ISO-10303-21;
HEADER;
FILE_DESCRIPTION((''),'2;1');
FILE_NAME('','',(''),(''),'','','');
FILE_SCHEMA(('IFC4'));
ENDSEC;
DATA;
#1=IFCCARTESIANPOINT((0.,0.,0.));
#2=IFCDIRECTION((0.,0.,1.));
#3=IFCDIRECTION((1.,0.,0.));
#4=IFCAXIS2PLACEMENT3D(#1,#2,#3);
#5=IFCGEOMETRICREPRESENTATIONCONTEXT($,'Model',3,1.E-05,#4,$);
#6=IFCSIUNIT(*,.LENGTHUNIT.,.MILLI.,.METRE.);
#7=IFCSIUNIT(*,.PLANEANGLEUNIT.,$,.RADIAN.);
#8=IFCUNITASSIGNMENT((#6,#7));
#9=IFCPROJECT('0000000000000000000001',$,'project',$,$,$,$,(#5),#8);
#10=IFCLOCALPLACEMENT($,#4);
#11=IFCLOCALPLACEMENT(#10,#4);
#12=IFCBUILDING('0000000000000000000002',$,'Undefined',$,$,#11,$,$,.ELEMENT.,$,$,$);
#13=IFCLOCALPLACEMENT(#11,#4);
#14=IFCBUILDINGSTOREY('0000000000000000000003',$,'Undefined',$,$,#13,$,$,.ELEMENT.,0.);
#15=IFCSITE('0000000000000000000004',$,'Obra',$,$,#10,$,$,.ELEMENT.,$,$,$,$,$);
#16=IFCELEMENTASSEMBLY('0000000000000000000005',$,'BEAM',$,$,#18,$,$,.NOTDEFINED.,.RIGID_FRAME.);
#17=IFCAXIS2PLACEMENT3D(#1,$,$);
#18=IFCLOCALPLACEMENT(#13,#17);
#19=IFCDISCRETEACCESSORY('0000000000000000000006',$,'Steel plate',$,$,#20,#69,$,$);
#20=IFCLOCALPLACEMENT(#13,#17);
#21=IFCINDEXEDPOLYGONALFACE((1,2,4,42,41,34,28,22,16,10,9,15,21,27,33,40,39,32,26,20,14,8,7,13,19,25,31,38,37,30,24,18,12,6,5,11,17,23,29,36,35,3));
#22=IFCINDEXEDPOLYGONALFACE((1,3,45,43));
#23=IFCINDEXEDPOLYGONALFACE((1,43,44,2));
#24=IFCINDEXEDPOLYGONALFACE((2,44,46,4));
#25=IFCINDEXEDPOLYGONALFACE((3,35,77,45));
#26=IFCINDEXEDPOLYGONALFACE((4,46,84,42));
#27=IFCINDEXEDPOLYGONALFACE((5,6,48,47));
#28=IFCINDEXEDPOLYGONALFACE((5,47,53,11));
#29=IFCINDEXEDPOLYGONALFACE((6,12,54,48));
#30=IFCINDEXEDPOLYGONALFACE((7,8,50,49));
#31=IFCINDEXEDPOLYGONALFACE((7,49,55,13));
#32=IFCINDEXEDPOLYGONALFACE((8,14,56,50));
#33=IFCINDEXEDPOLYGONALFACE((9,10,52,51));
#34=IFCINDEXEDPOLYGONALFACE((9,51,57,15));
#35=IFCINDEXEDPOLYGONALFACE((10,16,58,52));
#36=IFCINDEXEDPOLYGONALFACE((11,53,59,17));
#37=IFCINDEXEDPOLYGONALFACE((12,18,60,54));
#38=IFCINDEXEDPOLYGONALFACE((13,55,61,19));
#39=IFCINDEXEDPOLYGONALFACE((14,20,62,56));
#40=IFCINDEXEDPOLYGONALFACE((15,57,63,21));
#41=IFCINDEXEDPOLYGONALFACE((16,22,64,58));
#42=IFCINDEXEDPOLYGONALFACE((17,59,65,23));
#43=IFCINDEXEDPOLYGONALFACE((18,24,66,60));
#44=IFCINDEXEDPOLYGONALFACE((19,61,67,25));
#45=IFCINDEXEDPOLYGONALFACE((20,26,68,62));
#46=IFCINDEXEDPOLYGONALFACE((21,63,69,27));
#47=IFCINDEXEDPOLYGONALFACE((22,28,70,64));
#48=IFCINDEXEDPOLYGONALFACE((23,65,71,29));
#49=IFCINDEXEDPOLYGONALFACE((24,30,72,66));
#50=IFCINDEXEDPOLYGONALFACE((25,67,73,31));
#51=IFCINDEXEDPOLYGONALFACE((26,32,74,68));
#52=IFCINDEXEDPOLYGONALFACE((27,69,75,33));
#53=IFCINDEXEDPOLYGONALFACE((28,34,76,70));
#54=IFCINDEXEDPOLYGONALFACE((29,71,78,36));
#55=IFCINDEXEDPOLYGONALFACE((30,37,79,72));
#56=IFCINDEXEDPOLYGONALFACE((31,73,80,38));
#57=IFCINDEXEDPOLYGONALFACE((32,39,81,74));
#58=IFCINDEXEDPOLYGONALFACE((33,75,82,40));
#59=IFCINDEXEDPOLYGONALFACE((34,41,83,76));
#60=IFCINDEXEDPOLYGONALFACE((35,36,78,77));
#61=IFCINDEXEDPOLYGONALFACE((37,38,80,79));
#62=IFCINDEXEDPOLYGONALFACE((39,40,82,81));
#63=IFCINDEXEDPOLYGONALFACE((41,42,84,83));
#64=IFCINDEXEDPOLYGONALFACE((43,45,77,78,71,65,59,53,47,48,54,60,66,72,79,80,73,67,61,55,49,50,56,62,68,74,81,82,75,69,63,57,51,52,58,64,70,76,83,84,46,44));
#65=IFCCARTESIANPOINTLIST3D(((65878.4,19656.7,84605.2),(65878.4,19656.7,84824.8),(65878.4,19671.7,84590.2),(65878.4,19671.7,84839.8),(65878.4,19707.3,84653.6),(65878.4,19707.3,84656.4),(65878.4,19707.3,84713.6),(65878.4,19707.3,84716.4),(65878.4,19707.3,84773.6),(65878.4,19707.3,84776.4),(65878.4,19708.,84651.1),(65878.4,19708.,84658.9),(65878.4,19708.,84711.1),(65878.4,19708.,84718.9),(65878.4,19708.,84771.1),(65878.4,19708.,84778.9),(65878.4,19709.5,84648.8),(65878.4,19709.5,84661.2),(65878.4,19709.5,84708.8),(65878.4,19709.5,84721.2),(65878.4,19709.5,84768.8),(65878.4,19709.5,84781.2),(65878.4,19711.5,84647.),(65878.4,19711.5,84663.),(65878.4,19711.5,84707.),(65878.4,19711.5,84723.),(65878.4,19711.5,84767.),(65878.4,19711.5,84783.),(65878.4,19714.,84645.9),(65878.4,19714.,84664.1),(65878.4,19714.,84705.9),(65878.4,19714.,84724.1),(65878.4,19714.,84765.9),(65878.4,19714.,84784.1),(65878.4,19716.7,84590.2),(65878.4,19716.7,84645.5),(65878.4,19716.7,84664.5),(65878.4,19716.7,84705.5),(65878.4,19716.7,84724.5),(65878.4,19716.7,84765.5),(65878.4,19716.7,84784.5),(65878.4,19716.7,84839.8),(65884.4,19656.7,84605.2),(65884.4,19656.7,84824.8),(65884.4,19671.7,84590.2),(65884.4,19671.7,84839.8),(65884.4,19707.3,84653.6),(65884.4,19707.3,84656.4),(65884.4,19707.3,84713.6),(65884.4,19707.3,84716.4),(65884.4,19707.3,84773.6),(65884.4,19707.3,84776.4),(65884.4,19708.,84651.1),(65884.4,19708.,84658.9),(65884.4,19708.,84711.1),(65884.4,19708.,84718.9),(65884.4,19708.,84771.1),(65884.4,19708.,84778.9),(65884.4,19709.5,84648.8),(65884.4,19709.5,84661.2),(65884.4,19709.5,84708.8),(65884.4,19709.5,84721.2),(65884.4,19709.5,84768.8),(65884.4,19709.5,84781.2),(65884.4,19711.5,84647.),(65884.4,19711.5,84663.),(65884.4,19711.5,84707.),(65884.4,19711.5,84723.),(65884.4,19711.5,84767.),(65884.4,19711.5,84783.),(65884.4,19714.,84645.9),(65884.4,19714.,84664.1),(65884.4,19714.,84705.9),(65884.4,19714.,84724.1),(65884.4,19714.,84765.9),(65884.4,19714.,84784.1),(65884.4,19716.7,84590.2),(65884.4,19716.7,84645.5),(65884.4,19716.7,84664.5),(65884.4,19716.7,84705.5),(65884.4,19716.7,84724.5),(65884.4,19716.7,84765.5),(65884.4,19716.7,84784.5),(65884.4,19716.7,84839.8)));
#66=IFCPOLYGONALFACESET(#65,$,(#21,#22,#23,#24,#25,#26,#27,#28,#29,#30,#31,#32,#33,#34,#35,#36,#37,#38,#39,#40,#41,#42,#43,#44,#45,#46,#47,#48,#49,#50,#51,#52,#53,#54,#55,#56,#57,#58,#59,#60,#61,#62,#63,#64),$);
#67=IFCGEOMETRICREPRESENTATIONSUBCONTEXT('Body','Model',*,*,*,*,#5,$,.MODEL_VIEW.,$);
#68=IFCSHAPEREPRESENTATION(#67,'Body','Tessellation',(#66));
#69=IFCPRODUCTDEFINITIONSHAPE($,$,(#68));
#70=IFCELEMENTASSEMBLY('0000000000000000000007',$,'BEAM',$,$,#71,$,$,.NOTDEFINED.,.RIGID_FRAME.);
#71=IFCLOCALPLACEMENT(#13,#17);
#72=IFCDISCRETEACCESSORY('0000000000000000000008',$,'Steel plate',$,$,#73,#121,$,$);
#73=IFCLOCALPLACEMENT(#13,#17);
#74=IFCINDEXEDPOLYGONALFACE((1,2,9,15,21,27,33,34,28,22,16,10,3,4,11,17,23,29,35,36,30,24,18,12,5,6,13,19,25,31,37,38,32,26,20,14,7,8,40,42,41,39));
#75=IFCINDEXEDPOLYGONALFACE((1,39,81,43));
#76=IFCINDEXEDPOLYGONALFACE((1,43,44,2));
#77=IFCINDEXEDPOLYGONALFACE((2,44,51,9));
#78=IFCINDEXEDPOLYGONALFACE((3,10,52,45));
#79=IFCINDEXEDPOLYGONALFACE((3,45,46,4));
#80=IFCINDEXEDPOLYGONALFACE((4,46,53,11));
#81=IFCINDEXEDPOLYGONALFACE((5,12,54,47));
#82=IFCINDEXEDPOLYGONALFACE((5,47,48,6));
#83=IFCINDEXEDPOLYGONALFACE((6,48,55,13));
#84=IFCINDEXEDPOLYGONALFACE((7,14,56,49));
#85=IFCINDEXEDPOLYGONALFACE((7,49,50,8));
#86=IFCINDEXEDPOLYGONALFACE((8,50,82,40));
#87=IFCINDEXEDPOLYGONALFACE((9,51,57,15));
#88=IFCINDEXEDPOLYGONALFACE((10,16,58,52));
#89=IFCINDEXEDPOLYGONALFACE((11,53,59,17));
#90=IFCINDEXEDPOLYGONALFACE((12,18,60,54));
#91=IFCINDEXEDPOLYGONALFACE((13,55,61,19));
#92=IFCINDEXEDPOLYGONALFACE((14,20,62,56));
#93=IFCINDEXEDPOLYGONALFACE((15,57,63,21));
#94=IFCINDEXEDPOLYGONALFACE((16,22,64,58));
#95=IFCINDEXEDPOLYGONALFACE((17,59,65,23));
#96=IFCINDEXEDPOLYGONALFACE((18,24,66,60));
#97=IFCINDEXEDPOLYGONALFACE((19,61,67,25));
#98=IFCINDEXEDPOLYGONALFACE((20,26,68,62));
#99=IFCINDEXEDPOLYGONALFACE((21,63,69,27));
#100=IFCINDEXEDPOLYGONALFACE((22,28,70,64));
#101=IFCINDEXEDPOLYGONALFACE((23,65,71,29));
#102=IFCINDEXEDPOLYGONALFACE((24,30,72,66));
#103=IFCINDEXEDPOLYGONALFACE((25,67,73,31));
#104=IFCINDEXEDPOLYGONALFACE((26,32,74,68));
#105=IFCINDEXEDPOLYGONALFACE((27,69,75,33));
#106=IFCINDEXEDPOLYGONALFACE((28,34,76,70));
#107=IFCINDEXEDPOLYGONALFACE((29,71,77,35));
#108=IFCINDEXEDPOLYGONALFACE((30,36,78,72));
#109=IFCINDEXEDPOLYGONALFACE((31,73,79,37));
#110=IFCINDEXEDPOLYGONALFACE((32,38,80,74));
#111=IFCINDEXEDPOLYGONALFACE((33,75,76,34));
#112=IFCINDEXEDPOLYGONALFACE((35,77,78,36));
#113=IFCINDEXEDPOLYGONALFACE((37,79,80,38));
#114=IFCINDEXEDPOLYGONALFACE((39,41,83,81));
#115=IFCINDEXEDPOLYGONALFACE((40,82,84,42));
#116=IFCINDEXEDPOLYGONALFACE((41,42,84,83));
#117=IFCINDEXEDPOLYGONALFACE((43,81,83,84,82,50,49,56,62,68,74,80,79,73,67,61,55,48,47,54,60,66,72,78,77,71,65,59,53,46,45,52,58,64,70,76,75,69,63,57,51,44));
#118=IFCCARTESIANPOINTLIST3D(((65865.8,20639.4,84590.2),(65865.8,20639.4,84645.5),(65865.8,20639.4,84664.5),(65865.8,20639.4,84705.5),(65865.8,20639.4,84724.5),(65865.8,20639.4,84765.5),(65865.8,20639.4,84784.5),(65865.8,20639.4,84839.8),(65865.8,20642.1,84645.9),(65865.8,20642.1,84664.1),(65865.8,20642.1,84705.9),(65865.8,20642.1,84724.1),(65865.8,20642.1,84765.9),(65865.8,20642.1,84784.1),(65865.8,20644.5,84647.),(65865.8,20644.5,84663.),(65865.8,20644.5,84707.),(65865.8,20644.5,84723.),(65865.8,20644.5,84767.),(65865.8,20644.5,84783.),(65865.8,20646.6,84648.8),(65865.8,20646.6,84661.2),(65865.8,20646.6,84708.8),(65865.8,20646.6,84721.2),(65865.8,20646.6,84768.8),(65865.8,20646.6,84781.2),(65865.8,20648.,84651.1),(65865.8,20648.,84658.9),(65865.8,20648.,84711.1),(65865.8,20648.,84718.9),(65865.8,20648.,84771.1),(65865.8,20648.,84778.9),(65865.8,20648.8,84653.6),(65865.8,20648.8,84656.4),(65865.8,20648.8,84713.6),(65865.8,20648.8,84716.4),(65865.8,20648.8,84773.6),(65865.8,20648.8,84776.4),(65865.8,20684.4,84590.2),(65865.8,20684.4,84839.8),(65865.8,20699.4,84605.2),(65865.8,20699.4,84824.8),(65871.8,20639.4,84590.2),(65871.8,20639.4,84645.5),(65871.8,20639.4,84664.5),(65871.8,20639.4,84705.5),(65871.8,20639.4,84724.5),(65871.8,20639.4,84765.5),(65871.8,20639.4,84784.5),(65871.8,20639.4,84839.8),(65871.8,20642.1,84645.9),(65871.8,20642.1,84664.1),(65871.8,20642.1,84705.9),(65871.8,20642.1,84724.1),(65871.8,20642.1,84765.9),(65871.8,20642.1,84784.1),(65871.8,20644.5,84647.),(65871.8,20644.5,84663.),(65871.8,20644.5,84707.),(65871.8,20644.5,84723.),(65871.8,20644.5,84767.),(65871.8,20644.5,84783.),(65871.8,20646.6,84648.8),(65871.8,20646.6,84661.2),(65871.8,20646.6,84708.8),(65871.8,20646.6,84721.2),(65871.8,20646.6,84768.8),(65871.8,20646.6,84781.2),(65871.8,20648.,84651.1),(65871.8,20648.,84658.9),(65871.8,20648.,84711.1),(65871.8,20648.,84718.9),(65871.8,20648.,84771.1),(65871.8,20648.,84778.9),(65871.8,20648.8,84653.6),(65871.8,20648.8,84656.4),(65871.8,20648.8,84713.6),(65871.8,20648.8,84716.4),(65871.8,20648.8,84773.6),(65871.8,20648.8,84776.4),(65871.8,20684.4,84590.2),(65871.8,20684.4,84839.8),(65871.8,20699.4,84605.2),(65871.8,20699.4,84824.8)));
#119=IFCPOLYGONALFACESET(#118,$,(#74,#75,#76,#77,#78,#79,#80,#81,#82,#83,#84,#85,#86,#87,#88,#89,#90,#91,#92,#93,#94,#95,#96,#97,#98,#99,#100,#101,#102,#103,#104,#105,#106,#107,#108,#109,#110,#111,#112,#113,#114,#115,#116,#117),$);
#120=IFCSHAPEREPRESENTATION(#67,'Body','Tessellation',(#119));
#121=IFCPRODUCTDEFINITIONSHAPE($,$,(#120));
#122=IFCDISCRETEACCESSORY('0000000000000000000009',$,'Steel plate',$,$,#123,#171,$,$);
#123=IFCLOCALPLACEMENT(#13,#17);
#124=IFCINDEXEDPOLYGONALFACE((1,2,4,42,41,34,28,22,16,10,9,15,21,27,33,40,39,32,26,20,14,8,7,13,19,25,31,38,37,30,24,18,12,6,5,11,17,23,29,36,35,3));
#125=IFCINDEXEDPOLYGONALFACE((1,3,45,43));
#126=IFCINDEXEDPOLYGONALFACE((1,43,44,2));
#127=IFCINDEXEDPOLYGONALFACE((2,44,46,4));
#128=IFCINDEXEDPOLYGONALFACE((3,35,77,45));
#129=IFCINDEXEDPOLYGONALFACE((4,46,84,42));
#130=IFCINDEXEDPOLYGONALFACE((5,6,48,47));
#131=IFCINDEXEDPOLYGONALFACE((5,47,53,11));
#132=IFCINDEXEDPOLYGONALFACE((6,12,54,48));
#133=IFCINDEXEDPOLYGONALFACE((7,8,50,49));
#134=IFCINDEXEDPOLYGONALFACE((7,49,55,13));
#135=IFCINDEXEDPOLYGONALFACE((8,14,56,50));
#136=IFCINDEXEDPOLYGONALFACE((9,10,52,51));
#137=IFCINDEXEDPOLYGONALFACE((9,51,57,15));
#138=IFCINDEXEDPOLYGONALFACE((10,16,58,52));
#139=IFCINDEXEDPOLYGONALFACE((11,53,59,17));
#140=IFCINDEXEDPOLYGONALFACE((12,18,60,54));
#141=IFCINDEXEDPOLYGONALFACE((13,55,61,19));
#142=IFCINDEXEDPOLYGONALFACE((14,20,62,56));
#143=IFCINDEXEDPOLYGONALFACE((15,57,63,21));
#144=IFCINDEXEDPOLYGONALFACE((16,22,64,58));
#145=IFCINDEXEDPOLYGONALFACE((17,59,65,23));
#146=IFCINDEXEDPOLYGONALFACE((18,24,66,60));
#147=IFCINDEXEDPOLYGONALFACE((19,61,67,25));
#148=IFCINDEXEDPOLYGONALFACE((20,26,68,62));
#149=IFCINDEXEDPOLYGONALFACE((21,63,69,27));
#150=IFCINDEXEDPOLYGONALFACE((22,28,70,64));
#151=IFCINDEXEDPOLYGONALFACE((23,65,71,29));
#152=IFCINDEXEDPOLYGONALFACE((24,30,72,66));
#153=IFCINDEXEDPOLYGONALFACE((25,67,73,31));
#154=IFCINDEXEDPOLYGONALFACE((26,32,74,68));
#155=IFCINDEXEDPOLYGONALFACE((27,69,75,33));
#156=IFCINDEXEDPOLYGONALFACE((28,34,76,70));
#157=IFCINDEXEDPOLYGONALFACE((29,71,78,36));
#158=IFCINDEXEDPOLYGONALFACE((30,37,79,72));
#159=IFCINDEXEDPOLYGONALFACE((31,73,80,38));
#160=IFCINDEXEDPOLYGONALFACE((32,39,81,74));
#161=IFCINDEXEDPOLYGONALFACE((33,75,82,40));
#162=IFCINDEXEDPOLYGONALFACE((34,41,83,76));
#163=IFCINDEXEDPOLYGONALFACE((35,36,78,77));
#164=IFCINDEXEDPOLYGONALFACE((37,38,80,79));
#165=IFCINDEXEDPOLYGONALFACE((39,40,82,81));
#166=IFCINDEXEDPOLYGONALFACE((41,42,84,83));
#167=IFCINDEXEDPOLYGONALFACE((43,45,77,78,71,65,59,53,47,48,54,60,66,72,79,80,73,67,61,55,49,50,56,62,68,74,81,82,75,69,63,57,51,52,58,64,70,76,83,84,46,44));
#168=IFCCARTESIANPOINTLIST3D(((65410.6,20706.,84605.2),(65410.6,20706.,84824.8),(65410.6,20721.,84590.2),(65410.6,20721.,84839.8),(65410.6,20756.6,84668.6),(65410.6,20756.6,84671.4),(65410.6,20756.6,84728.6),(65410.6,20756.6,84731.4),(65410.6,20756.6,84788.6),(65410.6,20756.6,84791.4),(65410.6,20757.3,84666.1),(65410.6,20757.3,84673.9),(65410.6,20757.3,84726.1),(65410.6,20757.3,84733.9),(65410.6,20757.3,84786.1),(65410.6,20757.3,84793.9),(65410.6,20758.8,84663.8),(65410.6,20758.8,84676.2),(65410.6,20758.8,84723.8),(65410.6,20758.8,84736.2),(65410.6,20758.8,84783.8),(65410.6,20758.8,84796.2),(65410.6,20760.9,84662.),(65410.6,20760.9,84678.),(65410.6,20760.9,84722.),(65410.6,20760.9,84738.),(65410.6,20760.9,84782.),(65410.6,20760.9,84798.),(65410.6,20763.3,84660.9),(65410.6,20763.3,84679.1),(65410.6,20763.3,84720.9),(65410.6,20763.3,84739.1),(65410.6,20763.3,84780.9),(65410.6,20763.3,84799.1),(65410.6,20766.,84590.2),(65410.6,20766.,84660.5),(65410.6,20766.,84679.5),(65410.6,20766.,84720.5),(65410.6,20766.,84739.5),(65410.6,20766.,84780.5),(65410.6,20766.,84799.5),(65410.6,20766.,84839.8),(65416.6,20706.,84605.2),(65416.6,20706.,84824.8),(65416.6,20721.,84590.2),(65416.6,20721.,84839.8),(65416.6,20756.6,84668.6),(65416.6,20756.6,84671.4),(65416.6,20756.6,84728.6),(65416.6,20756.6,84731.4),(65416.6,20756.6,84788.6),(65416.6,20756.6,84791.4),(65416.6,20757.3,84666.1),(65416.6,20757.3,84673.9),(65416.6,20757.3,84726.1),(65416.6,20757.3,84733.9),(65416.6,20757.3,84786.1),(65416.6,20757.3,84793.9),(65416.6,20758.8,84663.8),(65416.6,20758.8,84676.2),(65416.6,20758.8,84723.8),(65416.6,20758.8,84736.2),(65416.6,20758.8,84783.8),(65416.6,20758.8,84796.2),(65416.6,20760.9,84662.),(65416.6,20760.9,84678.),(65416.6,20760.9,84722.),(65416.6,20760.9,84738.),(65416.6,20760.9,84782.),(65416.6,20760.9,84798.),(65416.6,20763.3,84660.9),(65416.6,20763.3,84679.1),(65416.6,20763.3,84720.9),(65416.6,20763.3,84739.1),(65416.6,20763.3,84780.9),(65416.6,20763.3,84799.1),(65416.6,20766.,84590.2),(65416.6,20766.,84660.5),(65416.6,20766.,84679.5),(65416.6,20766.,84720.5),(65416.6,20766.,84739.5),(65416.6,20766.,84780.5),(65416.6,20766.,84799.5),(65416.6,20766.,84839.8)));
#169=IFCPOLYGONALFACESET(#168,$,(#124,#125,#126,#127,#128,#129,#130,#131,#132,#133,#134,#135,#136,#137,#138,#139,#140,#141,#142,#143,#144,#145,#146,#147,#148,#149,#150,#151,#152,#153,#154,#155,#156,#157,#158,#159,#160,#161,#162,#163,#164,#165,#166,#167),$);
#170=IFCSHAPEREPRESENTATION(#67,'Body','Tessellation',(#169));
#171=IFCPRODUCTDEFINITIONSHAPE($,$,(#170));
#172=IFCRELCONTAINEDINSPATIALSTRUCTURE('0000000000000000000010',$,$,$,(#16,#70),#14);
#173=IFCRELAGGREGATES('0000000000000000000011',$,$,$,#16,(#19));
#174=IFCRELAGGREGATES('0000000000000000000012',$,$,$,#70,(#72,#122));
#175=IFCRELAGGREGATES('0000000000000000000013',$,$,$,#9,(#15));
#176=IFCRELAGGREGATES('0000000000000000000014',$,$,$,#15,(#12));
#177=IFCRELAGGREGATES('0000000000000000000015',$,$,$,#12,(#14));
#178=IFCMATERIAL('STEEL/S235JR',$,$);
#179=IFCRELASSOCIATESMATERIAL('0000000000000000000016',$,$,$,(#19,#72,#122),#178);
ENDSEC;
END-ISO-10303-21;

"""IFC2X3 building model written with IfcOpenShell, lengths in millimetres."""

from ifc_helpers import new_model, si_unit, frame, origin_with_axes, origin_2d_with_axis, place, context, subcontext, project, spatial, polyline, circle, outline, extrude, source, transform, mapped, material, element, aggregate, save


model = new_model("IFC2X3")

# Units and contexts
model_context = context("Model", 3, precision=1e-05, world=origin_with_axes())
body_context = subcontext(model_context, "Body", "Model", "MODEL_VIEW")
ifc_project = project(units=[si_unit("LENGTHUNIT", "METRE", prefix="MILLI"), si_unit("PLANEANGLEUNIT", "RADIAN")], contexts=[model_context])

# Site, building, storey
site_placement = place(None, origin_with_axes())
site = spatial("IfcSite", under=ifc_project, at=site_placement, Name="Obra", CompositionType="ELEMENT")
building_placement = place(site_placement, origin_with_axes())
building = spatial("IfcBuilding", under=site, at=building_placement, Name="Undefined", CompositionType="ELEMENT")
storey_placement = place(building_placement, origin_with_axes())
storey = spatial("IfcBuildingStorey", under=building, at=storey_placement, Name="Undefined", CompositionType="ELEMENT", Elevation=0.0)

# Shared definitions
ifc_material = material(Name="STEEL/S235JR")

# Element assemblies, discrete accessories, openings
shared_shape_1 = source(origin_with_axes(), body_context, "Body", "SweptSolid", [
    extrude(circle(Radius=9.5, at=origin_2d_with_axis()), frame((0.0, -9.4, 0.0), z_axis=(0.0, 1.0, 0.0), x_axis=(1.0, 0.0, 0.0)), (0.0, 0.0, 1.0), 6.2),
])
assembly_1_placement = place(storey_placement, origin_with_axes())
assembly_1 = element("IfcElementAssembly", 1, at=assembly_1_placement, inside=storey, Name="BEAM", AssemblyPlace="NOTDEFINED", PredefinedType="RIGID_FRAME")
discrete_accessory_1_placement = place(assembly_1_placement, frame((65881.4, 19716.7, 84590.2), z_axis=(-1.0, -0.000002, 0.0), x_axis=(0.000002, -1.0, 0.0)))
discrete_accessory_1 = element("IfcDiscreteAccessory", 2, at=discrete_accessory_1_placement, material=ifc_material, Name="Steel plate", context=body_context, shape_type="SweptSolid", body=[
    extrude(outline(polyline([(0.0, 0.0), (45.0, 0.0), (60.0, 15.0), (60.0, 234.6), (45.0, 249.6), (0.0, 249.6), (0.0, 0.0)])), frame((0.0, 0.0, -3.0), z_axis=(0.0, 0.0, 1.0), x_axis=(1.0, 0.0, 0.0)), (0.0, 0.0, 1.0), 6.0),
])
opening_1_placement = place(assembly_1_placement, frame((65875.1, 19666.7, 84850.0), z_axis=(-0.000002, 1.0, 0.0), x_axis=(0.0, 0.0, -1.0)))
element("IfcOpeningElement", 3, at=opening_1_placement, cuts=discrete_accessory_1, ObjectType="Opening", context=body_context, shape_type="MappedRepresentation", body=[
    mapped(shared_shape_1, transform((75.0, 0.0, 50.0))),
    mapped(shared_shape_1, transform((135.0, 0.0, 50.0))),
    mapped(shared_shape_1, transform((195.0, 0.0, 50.0))),
])
aggregate(assembly_1, [discrete_accessory_1])
assembly_2_placement = place(storey_placement, origin_with_axes())
assembly_2 = element("IfcElementAssembly", 4, at=assembly_2_placement, inside=storey, Name="BEAM", AssemblyPlace="NOTDEFINED", PredefinedType="RIGID_FRAME")
discrete_accessory_2_placement = place(assembly_2_placement, frame((65868.8, 20639.4, 84590.2), z_axis=(1.0, 0.000001, 0.0), x_axis=(-0.000002, 1.0, 0.0)))
discrete_accessory_2 = element("IfcDiscreteAccessory", 5, at=discrete_accessory_2_placement, material=ifc_material, Name="Steel plate", context=body_context, shape_type="SweptSolid", body=[
    extrude(outline(polyline([(0.0, 0.0), (45.0, 0.0), (60.0, 15.0), (60.0, 234.6), (45.0, 249.6), (0.0, 249.6), (0.0, 0.0)])), frame((0.0, 0.0, -3.0), z_axis=(0.0, 0.0, 1.0), x_axis=(1.0, 0.0, 0.0)), (0.0, 0.0, 1.0), 6.0),
])
opening_2_placement = place(assembly_2_placement, frame((65875.1, 20689.4, 84850.0), z_axis=(0.000002, -1.0, 0.0), x_axis=(0.0, 0.0, -1.0)))
element("IfcOpeningElement", 6, at=opening_2_placement, cuts=discrete_accessory_2, ObjectType="Opening", context=body_context, shape_type="MappedRepresentation", body=[
    mapped(shared_shape_1, transform((75.0, 0.0, 50.0))),
    mapped(shared_shape_1, transform((135.0, 0.0, 50.0))),
    mapped(shared_shape_1, transform((195.0, 0.0, 50.0))),
])
discrete_accessory_3_placement = place(assembly_2_placement, frame((65413.6, 20766.0, 84590.2), z_axis=(-1.0, -0.000002, 0.0), x_axis=(0.000002, -1.0, 0.0)))
discrete_accessory_3 = element("IfcDiscreteAccessory", 7, at=discrete_accessory_3_placement, material=ifc_material, Name="Steel plate", context=body_context, shape_type="SweptSolid", body=[
    extrude(outline(polyline([(0.0, 0.0), (45.0, 0.0), (60.0, 15.0), (60.0, 234.6), (45.0, 249.6), (0.0, 249.6), (0.0, 0.0)])), frame((0.0, 0.0, -3.0), z_axis=(0.0, 0.0, 1.0), x_axis=(1.0, 0.0, 0.0)), (0.0, 0.0, 1.0), 6.0),
])
shared_shape_2 = source(origin_with_axes(), body_context, "Body", "SweptSolid", [
    extrude(circle(Radius=9.5, at=origin_2d_with_axis()), frame((0.0, -9.2, 0.0), z_axis=(0.0, 1.0, 0.0), x_axis=(1.0, 0.0, 0.0)), (0.0, 0.0, 1.0), 6.2),
])
opening_3_placement = place(assembly_2_placement, frame((65407.5, 20716.0, 84850.0), z_axis=(-0.000002, 1.0, 0.0), x_axis=(0.0, 0.0, -1.0)))
element("IfcOpeningElement", 8, at=opening_3_placement, cuts=discrete_accessory_3, ObjectType="Opening", context=body_context, shape_type="MappedRepresentation", body=[
    mapped(shared_shape_2, transform((60.0, 0.0, 50.0))),
    mapped(shared_shape_2, transform((120.0, 0.0, 50.0))),
    mapped(shared_shape_2, transform((180.0, 0.0, 50.0))),
])
aggregate(assembly_2, [discrete_accessory_2, discrete_accessory_3])

save(model, "model.ifc")
